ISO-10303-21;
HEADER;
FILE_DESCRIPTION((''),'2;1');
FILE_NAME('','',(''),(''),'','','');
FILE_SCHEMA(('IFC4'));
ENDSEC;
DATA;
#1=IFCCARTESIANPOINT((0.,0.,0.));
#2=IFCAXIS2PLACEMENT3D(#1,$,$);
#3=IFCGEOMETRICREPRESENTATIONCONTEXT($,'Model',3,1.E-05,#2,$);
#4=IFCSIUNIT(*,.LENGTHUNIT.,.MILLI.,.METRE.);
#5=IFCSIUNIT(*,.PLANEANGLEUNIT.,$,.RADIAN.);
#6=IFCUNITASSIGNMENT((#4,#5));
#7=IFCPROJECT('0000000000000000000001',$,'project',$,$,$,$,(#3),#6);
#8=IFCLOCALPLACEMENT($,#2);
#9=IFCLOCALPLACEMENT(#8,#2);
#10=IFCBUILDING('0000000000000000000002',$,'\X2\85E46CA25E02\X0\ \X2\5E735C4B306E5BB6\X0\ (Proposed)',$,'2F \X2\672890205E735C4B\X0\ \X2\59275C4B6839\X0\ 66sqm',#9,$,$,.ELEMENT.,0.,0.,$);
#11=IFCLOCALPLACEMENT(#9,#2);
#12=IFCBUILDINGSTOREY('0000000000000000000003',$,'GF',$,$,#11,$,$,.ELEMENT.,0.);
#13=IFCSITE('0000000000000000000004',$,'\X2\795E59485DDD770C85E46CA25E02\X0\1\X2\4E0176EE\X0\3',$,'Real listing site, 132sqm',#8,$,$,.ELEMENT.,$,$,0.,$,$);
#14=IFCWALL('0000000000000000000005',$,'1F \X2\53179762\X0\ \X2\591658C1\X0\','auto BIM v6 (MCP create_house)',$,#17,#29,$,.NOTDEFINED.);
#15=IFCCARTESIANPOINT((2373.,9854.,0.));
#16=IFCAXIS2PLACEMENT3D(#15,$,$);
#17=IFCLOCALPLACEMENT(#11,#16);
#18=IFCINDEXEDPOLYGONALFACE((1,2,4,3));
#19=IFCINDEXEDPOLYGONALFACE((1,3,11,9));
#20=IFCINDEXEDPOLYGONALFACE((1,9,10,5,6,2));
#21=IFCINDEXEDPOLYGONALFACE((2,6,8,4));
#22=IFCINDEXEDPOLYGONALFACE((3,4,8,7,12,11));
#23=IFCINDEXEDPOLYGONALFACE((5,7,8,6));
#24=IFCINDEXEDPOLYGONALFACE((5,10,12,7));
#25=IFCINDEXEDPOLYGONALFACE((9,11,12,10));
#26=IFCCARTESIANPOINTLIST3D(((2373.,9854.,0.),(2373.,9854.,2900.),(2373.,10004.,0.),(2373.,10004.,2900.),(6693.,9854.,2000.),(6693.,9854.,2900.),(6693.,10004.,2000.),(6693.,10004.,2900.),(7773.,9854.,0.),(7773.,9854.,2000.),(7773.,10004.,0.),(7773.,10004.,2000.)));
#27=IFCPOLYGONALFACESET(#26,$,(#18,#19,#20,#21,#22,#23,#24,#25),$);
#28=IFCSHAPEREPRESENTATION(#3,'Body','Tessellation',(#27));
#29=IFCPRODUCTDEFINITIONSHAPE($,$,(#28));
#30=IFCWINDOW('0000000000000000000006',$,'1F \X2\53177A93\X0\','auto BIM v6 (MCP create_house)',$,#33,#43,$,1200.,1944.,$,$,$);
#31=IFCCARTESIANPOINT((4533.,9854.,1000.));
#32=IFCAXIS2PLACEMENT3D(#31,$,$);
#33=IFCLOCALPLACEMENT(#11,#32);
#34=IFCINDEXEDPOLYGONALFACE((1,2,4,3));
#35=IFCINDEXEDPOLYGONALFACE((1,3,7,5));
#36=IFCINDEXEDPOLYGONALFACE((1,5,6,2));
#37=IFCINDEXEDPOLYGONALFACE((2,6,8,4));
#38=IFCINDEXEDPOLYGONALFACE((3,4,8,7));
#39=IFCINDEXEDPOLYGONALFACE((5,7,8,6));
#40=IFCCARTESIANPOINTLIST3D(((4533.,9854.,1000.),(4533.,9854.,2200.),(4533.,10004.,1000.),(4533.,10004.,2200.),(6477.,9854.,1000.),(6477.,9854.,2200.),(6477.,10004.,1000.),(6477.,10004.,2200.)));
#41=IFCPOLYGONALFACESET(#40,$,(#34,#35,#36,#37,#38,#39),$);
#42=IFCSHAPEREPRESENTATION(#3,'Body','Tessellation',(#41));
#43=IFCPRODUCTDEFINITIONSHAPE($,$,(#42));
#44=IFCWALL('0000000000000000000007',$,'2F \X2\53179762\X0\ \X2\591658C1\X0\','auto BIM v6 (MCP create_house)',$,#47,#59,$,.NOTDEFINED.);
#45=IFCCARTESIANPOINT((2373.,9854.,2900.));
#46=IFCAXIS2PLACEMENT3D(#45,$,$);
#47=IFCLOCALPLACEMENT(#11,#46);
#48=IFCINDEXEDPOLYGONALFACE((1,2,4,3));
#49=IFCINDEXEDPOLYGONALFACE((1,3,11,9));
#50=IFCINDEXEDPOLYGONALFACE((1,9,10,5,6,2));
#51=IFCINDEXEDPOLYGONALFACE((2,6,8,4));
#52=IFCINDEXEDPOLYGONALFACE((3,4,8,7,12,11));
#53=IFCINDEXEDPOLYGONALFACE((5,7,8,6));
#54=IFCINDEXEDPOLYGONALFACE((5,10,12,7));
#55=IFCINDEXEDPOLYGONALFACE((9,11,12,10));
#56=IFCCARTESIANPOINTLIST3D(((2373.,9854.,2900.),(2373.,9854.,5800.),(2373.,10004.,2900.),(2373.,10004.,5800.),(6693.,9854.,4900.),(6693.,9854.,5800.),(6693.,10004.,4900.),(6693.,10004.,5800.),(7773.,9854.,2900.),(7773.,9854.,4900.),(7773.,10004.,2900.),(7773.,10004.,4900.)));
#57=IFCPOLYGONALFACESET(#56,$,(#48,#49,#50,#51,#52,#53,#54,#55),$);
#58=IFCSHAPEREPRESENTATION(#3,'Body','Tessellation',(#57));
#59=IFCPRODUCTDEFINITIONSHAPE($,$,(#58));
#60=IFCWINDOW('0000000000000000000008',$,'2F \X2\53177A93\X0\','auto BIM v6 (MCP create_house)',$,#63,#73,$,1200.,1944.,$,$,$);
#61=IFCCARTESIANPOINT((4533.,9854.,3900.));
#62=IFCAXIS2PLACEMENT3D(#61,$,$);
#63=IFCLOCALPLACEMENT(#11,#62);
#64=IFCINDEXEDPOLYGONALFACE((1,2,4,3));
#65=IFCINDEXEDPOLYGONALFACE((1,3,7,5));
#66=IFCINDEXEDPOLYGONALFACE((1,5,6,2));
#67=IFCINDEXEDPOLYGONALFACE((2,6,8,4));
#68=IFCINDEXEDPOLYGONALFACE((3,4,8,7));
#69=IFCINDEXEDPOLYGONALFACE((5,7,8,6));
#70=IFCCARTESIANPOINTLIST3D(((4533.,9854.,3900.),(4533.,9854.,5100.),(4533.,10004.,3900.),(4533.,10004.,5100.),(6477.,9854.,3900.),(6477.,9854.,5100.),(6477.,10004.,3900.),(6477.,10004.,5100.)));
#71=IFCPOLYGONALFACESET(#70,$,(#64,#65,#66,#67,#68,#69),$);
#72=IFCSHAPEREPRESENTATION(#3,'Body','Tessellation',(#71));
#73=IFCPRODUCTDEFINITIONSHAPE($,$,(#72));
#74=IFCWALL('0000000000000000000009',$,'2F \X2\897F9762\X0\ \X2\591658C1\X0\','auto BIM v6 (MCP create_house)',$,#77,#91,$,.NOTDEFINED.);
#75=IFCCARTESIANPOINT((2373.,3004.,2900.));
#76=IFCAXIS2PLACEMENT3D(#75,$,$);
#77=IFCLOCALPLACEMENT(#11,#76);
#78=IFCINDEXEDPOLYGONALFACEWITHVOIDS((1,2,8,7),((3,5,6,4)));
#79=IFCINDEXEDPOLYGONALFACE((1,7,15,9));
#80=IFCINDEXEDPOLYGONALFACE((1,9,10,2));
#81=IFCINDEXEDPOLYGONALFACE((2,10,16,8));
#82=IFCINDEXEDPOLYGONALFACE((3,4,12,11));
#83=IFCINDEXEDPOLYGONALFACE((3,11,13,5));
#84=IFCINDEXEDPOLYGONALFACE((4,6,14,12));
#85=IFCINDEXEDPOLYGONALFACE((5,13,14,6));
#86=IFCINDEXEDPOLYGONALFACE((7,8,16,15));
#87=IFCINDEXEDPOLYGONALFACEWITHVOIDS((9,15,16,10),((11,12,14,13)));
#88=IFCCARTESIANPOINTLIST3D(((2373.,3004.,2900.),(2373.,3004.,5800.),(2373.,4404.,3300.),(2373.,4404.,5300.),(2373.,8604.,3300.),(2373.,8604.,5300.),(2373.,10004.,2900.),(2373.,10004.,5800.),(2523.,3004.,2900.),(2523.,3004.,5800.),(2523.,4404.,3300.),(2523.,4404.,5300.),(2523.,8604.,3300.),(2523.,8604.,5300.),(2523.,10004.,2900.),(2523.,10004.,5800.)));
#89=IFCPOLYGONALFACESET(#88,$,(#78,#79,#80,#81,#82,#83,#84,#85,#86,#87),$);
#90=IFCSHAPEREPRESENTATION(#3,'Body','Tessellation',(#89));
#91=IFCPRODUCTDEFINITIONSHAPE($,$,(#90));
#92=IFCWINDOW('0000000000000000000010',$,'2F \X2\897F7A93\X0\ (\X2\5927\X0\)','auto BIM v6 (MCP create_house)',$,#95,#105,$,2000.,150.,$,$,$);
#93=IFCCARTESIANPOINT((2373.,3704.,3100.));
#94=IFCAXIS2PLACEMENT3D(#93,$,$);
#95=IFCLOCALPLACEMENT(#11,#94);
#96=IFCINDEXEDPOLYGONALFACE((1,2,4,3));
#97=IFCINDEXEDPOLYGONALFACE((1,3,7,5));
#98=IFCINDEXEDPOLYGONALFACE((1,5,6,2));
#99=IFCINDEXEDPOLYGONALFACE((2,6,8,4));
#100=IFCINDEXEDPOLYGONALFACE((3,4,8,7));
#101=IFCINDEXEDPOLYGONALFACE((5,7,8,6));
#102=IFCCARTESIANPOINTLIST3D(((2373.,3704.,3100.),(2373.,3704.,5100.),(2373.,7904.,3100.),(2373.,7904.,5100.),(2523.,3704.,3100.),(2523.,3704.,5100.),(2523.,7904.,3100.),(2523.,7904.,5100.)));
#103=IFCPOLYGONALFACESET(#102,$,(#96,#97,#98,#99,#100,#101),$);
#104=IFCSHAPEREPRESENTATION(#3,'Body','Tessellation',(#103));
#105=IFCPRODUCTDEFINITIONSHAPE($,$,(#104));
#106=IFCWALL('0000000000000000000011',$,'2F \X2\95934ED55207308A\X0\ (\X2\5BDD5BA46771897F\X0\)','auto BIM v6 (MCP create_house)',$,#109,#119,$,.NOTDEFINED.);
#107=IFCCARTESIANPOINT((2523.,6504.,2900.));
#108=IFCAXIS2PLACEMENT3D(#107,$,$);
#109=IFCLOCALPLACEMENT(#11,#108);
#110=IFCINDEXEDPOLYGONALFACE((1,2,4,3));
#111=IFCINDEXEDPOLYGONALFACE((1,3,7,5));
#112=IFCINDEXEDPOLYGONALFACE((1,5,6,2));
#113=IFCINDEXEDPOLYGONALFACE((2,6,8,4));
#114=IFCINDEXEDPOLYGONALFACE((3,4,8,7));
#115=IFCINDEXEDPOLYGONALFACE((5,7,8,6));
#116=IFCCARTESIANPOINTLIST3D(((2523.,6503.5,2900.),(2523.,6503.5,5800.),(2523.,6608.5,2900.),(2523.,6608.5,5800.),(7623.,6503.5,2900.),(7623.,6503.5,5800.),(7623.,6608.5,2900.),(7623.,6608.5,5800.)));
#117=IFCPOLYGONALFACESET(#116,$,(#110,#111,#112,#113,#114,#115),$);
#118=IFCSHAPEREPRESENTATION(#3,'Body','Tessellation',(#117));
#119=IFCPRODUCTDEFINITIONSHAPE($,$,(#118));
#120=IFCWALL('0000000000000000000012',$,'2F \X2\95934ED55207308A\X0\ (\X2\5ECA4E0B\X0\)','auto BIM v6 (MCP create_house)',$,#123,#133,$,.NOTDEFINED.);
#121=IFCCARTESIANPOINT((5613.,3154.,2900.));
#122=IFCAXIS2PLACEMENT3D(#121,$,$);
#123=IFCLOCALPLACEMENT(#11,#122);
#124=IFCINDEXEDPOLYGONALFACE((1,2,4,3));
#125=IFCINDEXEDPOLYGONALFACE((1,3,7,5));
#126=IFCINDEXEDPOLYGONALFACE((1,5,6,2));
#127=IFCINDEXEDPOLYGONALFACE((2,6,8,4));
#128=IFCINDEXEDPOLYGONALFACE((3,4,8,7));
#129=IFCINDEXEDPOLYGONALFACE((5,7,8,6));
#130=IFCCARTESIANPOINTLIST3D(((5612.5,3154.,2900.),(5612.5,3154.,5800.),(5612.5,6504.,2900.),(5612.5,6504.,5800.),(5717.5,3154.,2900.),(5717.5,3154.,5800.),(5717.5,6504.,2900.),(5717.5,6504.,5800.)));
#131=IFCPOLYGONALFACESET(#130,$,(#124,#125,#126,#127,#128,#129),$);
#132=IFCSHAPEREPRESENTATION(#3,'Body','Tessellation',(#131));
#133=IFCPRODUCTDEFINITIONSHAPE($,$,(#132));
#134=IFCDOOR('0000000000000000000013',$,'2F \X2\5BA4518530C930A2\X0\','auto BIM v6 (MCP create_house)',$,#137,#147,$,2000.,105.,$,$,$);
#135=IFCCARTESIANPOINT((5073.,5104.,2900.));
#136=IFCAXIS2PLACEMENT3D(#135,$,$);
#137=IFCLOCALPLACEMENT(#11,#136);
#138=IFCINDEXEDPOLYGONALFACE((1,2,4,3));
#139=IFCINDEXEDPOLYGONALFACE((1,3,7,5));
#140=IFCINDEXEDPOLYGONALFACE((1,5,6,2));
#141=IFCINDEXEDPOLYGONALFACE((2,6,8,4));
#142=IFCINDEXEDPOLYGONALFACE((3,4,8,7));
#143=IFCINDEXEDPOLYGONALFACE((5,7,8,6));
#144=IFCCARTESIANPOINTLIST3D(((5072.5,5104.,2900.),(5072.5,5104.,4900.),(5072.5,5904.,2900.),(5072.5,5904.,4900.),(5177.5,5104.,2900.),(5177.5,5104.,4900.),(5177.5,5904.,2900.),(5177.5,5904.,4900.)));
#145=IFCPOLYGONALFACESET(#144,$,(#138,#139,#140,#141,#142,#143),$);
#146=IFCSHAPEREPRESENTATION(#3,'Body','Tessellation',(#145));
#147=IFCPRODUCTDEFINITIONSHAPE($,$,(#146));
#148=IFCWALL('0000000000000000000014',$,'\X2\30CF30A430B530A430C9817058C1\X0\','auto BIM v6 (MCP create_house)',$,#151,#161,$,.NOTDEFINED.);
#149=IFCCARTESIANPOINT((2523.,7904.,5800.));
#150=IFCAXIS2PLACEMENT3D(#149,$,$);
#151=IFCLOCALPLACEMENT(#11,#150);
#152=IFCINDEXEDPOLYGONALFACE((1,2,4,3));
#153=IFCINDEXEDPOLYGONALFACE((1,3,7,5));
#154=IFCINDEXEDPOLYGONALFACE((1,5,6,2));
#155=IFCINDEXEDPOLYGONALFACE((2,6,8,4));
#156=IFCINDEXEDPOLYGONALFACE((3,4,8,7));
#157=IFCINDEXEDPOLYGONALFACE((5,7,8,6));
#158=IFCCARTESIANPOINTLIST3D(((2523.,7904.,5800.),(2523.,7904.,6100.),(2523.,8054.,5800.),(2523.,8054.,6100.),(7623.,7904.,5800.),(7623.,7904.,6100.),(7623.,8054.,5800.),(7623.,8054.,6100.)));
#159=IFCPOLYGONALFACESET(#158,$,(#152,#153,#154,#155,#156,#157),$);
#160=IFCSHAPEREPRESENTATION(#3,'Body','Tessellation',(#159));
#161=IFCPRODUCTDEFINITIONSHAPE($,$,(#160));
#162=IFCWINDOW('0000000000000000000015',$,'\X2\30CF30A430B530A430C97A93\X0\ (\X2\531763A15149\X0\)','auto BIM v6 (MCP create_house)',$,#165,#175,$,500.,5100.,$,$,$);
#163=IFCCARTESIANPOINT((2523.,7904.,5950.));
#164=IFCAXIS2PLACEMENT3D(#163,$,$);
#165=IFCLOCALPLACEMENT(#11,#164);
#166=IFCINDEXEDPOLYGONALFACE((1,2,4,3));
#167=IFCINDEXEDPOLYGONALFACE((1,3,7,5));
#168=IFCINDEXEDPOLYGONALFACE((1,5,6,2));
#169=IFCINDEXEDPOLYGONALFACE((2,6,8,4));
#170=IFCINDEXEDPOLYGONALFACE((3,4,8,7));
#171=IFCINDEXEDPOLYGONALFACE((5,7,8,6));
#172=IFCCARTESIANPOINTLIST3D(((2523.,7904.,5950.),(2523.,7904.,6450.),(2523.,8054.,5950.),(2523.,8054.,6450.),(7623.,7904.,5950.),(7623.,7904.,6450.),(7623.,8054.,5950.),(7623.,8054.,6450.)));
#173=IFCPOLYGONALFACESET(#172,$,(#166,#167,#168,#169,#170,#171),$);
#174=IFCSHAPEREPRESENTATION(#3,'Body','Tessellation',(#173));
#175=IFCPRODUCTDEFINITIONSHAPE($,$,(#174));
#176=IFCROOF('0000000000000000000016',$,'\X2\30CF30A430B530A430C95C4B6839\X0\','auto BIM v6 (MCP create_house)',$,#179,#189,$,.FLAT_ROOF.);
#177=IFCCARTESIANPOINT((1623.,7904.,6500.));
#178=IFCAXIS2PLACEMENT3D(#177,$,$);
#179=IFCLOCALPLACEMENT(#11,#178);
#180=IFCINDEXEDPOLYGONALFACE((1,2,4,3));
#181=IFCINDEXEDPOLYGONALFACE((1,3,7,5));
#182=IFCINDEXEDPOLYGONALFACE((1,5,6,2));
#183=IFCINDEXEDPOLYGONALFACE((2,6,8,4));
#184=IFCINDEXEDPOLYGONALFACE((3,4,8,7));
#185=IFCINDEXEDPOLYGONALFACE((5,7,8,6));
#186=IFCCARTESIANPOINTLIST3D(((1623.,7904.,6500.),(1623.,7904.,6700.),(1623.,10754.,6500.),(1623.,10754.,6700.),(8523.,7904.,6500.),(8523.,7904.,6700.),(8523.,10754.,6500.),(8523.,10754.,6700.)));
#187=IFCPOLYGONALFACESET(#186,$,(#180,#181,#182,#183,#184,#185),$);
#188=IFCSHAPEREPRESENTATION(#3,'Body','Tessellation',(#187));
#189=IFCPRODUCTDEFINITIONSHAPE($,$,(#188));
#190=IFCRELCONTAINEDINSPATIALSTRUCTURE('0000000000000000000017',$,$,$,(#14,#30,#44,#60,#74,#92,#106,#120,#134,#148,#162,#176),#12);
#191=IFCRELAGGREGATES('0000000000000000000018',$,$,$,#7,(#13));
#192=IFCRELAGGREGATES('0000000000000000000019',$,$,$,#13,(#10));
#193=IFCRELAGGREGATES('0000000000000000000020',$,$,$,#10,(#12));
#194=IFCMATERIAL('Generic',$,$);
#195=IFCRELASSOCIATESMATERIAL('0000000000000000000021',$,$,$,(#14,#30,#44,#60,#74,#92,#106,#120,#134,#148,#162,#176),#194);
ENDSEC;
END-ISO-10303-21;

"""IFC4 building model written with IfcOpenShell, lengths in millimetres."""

from ifc_helpers import new_model, si_unit, frame, frame_2d, origin, place, context, project, spatial, rectangle, extrude, material, element, fill, save


model = new_model("IFC4")

# Units and contexts
model_context = context("Model", 3, precision=1e-05, world=origin())
ifc_project = project(units=[si_unit("LENGTHUNIT", "METRE", prefix="MILLI"), si_unit("PLANEANGLEUNIT", "RADIAN")], contexts=[model_context])

# Site, building, storey
site_placement = place(None, origin())
site = spatial("IfcSite", under=ifc_project, at=site_placement, Name="神奈川県藤沢市1丁目3", ObjectType="Real listing site, 132sqm", CompositionType="ELEMENT", RefElevation=0.0)
building_placement = place(site_placement, origin())
building = spatial("IfcBuilding", under=site, at=building_placement, Name="藤沢市 平屋の家 (Proposed)", ObjectType="2F 木造平屋 大屋根 66sqm", CompositionType="ELEMENT", ElevationOfRefHeight=0.0, ElevationOfTerrain=0.0)
storey_placement = place(building_placement, origin())
storey = spatial("IfcBuildingStorey", under=building, at=storey_placement, Name="GF", CompositionType="ELEMENT", Elevation=0.0)

# Wall, opening, window
ifc_material = material(Name="Generic")
wall_1_placement = place(storey_placement, frame((2373.0, 9854.0, 0.0)))
wall_1 = element("IfcWall", 1, at=wall_1_placement, inside=storey, material=ifc_material, Name="1F 北面 外壁", Description="auto BIM v6 (MCP create_house)", PredefinedType="NOTDEFINED", context=model_context, shape_type="SweptSolid", body=[
    extrude(rectangle(XDim=5400.0, YDim=150.0, at=frame_2d((2700.0, 75.0))), frame((2373.0, 9854.0, 0.0)), (0.0, 0.0, 1.0), 2900.0),
])
opening_1_placement = place(storey_placement, frame((4533.0, 9854.0, 1000.0)))
opening_1 = element("IfcOpeningElement", 2, at=opening_1_placement, cuts=wall_1, PredefinedType="NOTDEFINED", context=model_context, shape_type="SweptSolid", body=[
    extrude(rectangle(XDim=1944.0, YDim=150.0, at=frame_2d((972.0, 75.0))), frame((4533.0, 9854.0, 1000.0)), (0.0, 0.0, 1.0), 1200.0),
])
window_1_placement = place(storey_placement, frame((4533.0, 9854.0, 1000.0)))
window_1 = element("IfcWindow", 3, at=window_1_placement, inside=storey, material=ifc_material, Name="1F 北窓", Description="auto BIM v6 (MCP create_house)", OverallHeight=1200.0, OverallWidth=1944.0, context=model_context, shape_type="SweptSolid", body=[
    extrude(rectangle(XDim=1944.0, YDim=150.0, at=frame_2d((972.0, 75.0))), frame((4533.0, 9854.0, 1000.0)), (0.0, 0.0, 1.0), 1200.0),
])
fill(opening_1, window_1)

# Walls, openings, windows
wall_2_placement = place(storey_placement, frame((2373.0, 9854.0, 2900.0)))
wall_2 = element("IfcWall", 4, at=wall_2_placement, inside=storey, material=ifc_material, Name="2F 北面 外壁", Description="auto BIM v6 (MCP create_house)", PredefinedType="NOTDEFINED", context=model_context, shape_type="SweptSolid", body=[
    extrude(rectangle(XDim=5400.0, YDim=150.0, at=frame_2d((2700.0, 75.0))), frame((2373.0, 9854.0, 2900.0)), (0.0, 0.0, 1.0), 2900.0),
])
opening_2_placement = place(storey_placement, frame((4533.0, 9854.0, 3900.0)))
opening_2 = element("IfcOpeningElement", 5, at=opening_2_placement, cuts=wall_2, PredefinedType="NOTDEFINED", context=model_context, shape_type="SweptSolid", body=[
    extrude(rectangle(XDim=1944.0, YDim=150.0, at=frame_2d((972.0, 75.0))), frame((4533.0, 9854.0, 3900.0)), (0.0, 0.0, 1.0), 1200.0),
])
window_2_placement = place(storey_placement, frame((4533.0, 9854.0, 3900.0)))
window_2 = element("IfcWindow", 6, at=window_2_placement, inside=storey, material=ifc_material, Name="2F 北窓", Description="auto BIM v6 (MCP create_house)", OverallHeight=1200.0, OverallWidth=1944.0, context=model_context, shape_type="SweptSolid", body=[
    extrude(rectangle(XDim=1944.0, YDim=150.0, at=frame_2d((972.0, 75.0))), frame((4533.0, 9854.0, 3900.0)), (0.0, 0.0, 1.0), 1200.0),
])
fill(opening_2, window_2)
wall_3_placement = place(storey_placement, frame((2373.0, 3004.0, 2900.0)))
wall_3 = element("IfcWall", 7, at=wall_3_placement, inside=storey, material=ifc_material, Name="2F 西面 外壁", Description="auto BIM v6 (MCP create_house)", PredefinedType="NOTDEFINED", context=model_context, shape_type="SweptSolid", body=[
    extrude(rectangle(XDim=150.0, YDim=7000.0, at=frame_2d((75.0, 3500.0))), frame((2373.0, 3004.0, 2900.0)), (0.0, 0.0, 1.0), 2900.0),
])
opening_3_placement = place(storey_placement, frame((2373.0, 3704.0, 3100.0)))
opening_3 = element("IfcOpeningElement", 8, at=opening_3_placement, cuts=wall_3, PredefinedType="NOTDEFINED", context=model_context, shape_type="SweptSolid", body=[
    extrude(rectangle(XDim=150.0, YDim=4200.0, at=frame_2d((75.0, 2100.0))), frame((2373.0, 3704.0, 3100.0)), (0.0, 0.0, 1.0), 2000.0),
])
window_3_placement = place(storey_placement, frame((2373.0, 3704.0, 3100.0)))
window_3 = element("IfcWindow", 9, at=window_3_placement, inside=storey, material=ifc_material, Name="2F 西窓 (大)", Description="auto BIM v6 (MCP create_house)", OverallHeight=2000.0, OverallWidth=150.0, context=model_context, shape_type="SweptSolid", body=[
    extrude(rectangle(XDim=150.0, YDim=4200.0, at=frame_2d((75.0, 2100.0))), frame((2373.0, 3704.0, 3100.0)), (0.0, 0.0, 1.0), 2000.0),
])
fill(opening_3, window_3)

# Walls
wall_4_placement = place(storey_placement, frame((2523.0, 6504.0, 2900.0)))
element("IfcWall", 10, at=wall_4_placement, inside=storey, material=ifc_material, Name="2F 間仕切り (寝室東西)", Description="auto BIM v6 (MCP create_house)", PredefinedType="NOTDEFINED", context=model_context, shape_type="SweptSolid", body=[
    extrude(rectangle(XDim=5100.0, YDim=105.0, at=frame_2d((2550.0, 52.0))), frame((2523.0, 6504.0, 2900.0)), (0.0, 0.0, 1.0), 2900.0),
])
wall_5_placement = place(storey_placement, frame((5613.0, 3154.0, 2900.0)))
element("IfcWall", 11, at=wall_5_placement, inside=storey, material=ifc_material, Name="2F 間仕切り (廊下)", Description="auto BIM v6 (MCP create_house)", PredefinedType="NOTDEFINED", context=model_context, shape_type="SweptSolid", body=[
    extrude(rectangle(XDim=105.0, YDim=3350.0, at=frame_2d((52.0, 1675.0))), frame((5613.0, 3154.0, 2900.0)), (0.0, 0.0, 1.0), 2900.0),
])

# Door
door_placement = place(storey_placement, frame((5073.0, 5104.0, 2900.0)))
element("IfcDoor", 12, at=door_placement, inside=storey, material=ifc_material, Name="2F 室内ドア", Description="auto BIM v6 (MCP create_house)", OverallHeight=2000.0, OverallWidth=105.0, context=model_context, shape_type="SweptSolid", body=[
    extrude(rectangle(XDim=105.0, YDim=800.0, at=frame_2d((52.0, 400.0))), frame((5073.0, 5104.0, 2900.0)), (0.0, 0.0, 1.0), 2000.0),
])

# Wall, opening, window
wall_6_placement = place(storey_placement, frame((2523.0, 7904.0, 5800.0)))
wall_6 = element("IfcWall", 13, at=wall_6_placement, inside=storey, material=ifc_material, Name="ハイサイド腰壁", Description="auto BIM v6 (MCP create_house)", PredefinedType="NOTDEFINED", context=model_context, shape_type="SweptSolid", body=[
    extrude(rectangle(XDim=5100.0, YDim=150.0, at=frame_2d((2550.0, 75.0))), frame((2523.0, 7904.0, 5800.0)), (0.0, 0.0, 1.0), 700.0),
])
opening_4_placement = place(storey_placement, frame((2523.0, 7904.0, 5950.0)))
opening_4 = element("IfcOpeningElement", 14, at=opening_4_placement, cuts=wall_6, PredefinedType="NOTDEFINED", context=model_context, shape_type="SweptSolid", body=[
    extrude(rectangle(XDim=5100.0, YDim=150.0, at=frame_2d((2550.0, 75.0))), frame((2523.0, 7904.0, 5950.0)), (0.0, 0.0, 1.0), 500.0),
])
window_4_placement = place(storey_placement, frame((2523.0, 7904.0, 5950.0)))
window_4 = element("IfcWindow", 15, at=window_4_placement, inside=storey, material=ifc_material, Name="ハイサイド窓 (北採光)", Description="auto BIM v6 (MCP create_house)", OverallHeight=500.0, OverallWidth=5100.0, context=model_context, shape_type="SweptSolid", body=[
    extrude(rectangle(XDim=5100.0, YDim=150.0, at=frame_2d((2550.0, 75.0))), frame((2523.0, 7904.0, 5950.0)), (0.0, 0.0, 1.0), 500.0),
])
fill(opening_4, window_4)

# Roof
roof_placement = place(storey_placement, frame((1623.0, 7904.0, 6500.0)))
element("IfcRoof", 16, at=roof_placement, inside=storey, material=ifc_material, Name="ハイサイド屋根", Description="auto BIM v6 (MCP create_house)", PredefinedType="FLAT_ROOF", context=model_context, shape_type="SweptSolid", body=[
    extrude(rectangle(XDim=6900.0, YDim=2850.0, at=frame_2d((3450.0, 1425.0))), frame((1623.0, 7904.0, 6500.0)), (0.0, 0.0, 1.0), 200.0),
])

save(model, "model.ifc")
